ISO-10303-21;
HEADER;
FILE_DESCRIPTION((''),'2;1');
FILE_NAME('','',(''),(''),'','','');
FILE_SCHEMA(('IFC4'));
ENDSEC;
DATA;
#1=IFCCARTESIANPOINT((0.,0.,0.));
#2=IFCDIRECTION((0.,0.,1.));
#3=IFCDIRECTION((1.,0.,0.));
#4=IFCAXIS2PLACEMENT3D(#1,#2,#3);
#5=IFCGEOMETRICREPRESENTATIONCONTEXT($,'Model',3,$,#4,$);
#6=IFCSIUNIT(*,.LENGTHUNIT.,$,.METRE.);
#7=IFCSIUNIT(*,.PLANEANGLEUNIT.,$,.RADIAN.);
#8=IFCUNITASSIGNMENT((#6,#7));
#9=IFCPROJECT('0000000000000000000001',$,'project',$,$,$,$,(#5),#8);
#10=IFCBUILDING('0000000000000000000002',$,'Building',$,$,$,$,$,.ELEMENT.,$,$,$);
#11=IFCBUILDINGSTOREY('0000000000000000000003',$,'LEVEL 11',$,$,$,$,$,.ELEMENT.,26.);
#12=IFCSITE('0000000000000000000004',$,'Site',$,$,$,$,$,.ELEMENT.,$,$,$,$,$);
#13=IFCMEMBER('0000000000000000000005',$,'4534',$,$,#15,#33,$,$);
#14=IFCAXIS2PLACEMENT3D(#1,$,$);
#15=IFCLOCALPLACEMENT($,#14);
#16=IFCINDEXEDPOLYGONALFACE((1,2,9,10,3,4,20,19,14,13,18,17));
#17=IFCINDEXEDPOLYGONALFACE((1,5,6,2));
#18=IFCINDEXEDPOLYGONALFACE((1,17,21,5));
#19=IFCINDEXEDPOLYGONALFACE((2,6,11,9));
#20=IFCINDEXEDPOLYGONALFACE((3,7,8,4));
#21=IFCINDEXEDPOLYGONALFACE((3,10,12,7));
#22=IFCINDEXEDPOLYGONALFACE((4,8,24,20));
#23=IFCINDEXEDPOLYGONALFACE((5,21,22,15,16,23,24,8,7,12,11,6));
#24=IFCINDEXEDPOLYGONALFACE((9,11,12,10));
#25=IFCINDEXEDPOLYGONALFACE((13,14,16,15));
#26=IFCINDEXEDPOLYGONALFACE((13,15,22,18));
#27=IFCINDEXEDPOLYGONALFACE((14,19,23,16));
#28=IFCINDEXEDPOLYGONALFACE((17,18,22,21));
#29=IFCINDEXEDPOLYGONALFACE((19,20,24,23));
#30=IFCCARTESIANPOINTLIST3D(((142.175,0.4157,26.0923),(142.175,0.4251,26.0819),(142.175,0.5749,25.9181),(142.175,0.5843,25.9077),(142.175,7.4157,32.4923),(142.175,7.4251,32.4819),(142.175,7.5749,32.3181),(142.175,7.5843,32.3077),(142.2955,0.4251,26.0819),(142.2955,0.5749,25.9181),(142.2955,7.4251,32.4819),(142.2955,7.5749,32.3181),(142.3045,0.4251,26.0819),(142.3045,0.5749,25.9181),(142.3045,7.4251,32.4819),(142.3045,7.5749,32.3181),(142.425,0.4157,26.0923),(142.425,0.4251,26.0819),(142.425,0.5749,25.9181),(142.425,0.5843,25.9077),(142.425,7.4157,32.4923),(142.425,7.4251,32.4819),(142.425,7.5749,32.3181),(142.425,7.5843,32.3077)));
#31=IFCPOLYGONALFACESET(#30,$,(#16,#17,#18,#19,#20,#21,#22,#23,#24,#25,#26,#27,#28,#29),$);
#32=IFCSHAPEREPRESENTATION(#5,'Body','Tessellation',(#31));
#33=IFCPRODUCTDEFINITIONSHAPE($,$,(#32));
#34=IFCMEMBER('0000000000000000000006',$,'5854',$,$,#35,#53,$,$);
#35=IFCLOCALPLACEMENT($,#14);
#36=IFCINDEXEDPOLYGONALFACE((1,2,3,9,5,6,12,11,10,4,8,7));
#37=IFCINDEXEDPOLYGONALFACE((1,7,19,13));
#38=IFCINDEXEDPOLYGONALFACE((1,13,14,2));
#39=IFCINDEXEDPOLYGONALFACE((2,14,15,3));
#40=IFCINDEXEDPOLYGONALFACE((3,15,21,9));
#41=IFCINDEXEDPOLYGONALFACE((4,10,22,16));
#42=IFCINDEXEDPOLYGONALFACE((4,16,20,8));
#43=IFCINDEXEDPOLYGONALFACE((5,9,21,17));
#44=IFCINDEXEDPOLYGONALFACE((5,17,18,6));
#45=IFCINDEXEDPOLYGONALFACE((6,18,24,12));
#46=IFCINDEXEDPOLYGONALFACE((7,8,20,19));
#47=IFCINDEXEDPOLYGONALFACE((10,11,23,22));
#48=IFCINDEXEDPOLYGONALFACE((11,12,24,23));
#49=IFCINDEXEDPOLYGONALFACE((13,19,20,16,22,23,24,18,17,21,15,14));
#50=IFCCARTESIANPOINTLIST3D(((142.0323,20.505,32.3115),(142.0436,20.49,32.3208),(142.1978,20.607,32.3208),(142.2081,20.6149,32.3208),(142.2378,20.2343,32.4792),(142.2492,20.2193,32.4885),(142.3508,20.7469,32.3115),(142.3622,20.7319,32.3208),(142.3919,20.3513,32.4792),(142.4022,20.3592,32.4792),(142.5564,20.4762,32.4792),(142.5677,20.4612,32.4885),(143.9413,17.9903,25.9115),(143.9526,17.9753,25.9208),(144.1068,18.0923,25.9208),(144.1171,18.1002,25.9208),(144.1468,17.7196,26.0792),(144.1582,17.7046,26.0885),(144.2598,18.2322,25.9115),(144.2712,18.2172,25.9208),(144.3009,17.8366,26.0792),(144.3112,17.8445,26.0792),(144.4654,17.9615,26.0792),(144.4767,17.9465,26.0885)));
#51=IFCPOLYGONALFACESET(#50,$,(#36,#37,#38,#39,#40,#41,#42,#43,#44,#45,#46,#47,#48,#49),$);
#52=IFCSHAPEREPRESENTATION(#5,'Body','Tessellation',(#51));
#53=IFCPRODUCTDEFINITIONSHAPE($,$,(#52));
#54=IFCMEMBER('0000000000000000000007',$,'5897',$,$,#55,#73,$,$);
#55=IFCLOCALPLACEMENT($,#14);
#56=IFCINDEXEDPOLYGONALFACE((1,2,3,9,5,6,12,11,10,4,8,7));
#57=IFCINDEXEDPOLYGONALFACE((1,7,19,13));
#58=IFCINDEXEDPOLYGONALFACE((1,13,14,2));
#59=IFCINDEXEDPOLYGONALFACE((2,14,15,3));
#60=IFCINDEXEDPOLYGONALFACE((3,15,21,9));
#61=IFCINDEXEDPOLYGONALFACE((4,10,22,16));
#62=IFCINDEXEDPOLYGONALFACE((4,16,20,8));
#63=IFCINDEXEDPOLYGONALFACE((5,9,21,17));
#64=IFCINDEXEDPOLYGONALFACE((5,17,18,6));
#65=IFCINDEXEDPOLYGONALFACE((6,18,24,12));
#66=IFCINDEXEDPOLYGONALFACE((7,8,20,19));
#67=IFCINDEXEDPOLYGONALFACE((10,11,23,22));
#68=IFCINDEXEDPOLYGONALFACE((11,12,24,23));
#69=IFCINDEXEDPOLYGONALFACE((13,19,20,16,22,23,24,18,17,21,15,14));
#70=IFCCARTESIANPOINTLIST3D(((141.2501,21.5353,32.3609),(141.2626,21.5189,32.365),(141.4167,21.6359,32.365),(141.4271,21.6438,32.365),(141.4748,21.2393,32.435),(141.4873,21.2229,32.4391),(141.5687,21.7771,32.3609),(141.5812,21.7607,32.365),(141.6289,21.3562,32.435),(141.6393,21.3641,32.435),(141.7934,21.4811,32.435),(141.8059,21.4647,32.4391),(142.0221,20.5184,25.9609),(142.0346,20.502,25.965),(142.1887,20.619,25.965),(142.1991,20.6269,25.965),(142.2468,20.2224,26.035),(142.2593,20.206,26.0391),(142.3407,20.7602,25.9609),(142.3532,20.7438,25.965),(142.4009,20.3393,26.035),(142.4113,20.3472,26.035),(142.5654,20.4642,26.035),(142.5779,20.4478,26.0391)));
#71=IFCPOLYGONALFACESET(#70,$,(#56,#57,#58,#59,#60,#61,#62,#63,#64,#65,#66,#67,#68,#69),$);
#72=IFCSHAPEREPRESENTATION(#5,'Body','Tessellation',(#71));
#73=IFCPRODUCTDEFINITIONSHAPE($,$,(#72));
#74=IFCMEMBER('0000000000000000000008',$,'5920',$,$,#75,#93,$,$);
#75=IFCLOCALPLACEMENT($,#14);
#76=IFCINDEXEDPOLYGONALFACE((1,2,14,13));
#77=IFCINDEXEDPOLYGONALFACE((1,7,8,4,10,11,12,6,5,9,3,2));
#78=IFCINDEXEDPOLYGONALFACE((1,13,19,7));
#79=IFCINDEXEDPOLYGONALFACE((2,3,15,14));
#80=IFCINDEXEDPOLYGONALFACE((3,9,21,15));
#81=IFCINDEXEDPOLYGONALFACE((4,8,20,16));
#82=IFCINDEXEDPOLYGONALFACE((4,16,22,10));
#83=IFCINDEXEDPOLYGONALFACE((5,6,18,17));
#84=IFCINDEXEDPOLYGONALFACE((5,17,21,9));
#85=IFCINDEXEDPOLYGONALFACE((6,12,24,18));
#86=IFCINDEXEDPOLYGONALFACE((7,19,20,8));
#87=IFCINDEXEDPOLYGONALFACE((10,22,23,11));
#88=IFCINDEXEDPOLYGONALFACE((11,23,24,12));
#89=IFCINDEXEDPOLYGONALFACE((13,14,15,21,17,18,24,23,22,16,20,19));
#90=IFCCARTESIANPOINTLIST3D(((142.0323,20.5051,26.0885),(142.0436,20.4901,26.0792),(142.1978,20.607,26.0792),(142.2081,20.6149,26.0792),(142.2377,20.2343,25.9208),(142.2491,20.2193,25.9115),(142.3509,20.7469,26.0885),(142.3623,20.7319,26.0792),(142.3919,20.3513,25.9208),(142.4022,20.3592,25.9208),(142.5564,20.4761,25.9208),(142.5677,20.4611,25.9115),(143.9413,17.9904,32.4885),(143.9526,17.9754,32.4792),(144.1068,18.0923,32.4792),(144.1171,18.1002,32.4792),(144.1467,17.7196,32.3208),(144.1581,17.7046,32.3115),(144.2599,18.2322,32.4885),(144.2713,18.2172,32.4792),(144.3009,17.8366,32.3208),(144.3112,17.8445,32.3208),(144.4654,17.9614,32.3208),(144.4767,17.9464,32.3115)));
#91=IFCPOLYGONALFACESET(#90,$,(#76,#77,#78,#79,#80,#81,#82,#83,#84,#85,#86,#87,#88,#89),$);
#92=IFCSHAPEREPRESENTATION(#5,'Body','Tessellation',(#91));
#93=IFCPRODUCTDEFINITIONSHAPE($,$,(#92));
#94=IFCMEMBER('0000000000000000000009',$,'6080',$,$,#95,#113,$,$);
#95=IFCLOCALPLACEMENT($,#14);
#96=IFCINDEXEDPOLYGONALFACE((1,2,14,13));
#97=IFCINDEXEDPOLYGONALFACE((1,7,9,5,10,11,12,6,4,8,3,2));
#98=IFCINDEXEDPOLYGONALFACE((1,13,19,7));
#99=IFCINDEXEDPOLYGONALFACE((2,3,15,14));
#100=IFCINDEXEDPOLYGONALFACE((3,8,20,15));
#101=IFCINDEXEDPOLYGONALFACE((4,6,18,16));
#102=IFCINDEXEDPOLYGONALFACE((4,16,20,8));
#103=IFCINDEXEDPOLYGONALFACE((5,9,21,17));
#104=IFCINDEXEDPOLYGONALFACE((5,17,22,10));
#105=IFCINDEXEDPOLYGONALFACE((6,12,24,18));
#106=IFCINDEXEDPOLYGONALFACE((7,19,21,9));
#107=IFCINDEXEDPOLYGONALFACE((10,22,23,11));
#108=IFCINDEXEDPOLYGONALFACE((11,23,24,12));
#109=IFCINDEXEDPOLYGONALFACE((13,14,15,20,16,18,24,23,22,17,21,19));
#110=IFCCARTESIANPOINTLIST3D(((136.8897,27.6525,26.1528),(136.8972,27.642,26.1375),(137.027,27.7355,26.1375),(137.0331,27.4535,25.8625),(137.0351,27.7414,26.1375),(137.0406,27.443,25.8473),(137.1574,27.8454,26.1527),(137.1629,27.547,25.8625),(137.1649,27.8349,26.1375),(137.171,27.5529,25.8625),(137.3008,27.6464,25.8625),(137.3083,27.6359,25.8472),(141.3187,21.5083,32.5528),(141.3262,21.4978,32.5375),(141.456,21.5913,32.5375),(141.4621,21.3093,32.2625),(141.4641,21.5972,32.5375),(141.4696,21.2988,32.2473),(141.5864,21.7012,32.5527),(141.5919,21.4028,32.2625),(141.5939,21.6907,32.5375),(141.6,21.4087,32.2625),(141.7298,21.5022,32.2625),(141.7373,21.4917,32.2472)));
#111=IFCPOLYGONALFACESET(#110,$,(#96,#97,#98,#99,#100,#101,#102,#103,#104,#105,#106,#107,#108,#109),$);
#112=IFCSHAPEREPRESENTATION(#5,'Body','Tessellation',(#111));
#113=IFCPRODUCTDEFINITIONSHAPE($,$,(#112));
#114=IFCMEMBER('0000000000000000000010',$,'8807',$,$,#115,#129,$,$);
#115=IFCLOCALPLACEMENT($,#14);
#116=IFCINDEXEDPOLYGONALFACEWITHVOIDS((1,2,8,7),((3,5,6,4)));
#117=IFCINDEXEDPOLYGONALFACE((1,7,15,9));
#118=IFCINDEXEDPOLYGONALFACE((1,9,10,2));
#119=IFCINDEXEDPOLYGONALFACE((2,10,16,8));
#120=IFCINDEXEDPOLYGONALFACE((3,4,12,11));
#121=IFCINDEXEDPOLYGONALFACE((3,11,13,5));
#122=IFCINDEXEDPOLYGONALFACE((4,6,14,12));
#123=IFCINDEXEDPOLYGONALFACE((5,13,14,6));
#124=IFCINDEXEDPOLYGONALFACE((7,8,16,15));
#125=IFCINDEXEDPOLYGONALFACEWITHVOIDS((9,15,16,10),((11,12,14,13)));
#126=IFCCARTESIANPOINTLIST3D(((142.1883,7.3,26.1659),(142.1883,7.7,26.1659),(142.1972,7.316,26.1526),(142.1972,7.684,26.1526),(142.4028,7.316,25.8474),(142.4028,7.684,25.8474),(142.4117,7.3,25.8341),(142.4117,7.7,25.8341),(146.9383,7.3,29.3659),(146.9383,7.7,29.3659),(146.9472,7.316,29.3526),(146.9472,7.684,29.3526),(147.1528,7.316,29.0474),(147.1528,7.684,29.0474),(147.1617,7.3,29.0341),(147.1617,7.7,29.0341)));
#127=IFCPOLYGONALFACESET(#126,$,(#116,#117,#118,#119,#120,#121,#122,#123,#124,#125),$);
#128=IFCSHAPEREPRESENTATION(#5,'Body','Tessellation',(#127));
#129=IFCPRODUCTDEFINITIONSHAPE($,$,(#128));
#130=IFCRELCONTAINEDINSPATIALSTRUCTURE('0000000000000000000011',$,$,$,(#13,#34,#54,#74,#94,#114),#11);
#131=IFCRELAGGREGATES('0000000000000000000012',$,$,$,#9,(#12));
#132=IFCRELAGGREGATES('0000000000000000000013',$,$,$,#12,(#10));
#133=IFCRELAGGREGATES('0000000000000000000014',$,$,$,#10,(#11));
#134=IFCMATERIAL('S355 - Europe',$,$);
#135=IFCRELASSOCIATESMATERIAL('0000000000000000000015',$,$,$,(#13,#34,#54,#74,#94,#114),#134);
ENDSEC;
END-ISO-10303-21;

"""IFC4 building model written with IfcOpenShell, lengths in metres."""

from ifc_helpers import new_model, si_unit, frame, origin_with_axes, origin_2d_with_axis, place, context, project, spatial, hollow_rectangle, i_section, extrude, material, material_profile, profile_set, profile_usage, element, save


model = new_model("IFC4")

# Units and contexts
model_context = context("Model", 3, world=origin_with_axes())
ifc_project = project(units=[si_unit("LENGTHUNIT", "METRE"), si_unit("PLANEANGLEUNIT", "RADIAN")], contexts=[model_context])

# Site, building, storey
site = spatial("IfcSite", under=ifc_project, Name="Site", CompositionType="ELEMENT")
building = spatial("IfcBuilding", under=site, Name="Building", CompositionType="ELEMENT")
storey = spatial("IfcBuildingStorey", under=building, Name="LEVEL 11", CompositionType="ELEMENT", Elevation=26.0)

# Shared definitions
ifc_material = material(Name="S355 - Europe")

# Members
ifc_material_profile_1 = material_profile(ifc_material, i_section(OverallWidth=0.25, OverallDepth=0.25, WebThickness=0.009, FlangeThickness=0.014, at=origin_2d_with_axis()))
ifc_profile_set_1 = profile_set([ifc_material_profile_1])
ifc_profile_usage_1 = profile_usage(ifc_profile_set_1, cardinal=10)
member_1_placement = place(None, frame((142.3, 7.5, 32.4), z_axis=(0.0, -0.738029, -0.674769), x_axis=(1.0, 0.0, 0.0)))
element("IfcMember", 1, at=member_1_placement, inside=storey, material=ifc_profile_usage_1, Name="4534", context=model_context, shape_type="SweptSolid", body=[
    extrude(i_section(OverallWidth=0.25, OverallDepth=0.25, WebThickness=0.009, FlangeThickness=0.014, at=origin_2d_with_axis()), origin_with_axes(), (0.0, 0.0, 1.0), 9.4847),
])
ifc_material_profile_2 = material_profile(ifc_material, i_section(OverallWidth=0.4, OverallDepth=0.4, WebThickness=0.013, FlangeThickness=0.021, at=origin_2d_with_axis()))
ifc_profile_set_2 = profile_set([ifc_material_profile_2])
ifc_profile_usage_2 = profile_usage(ifc_profile_set_2, cardinal=10)
member_2_placement = place(None, frame((144.209, 17.9684, 26.0), z_axis=(-0.267502, 0.352377, 0.896813), x_axis=(-0.796493, -0.604647, 0.0)))
element("IfcMember", 2, at=member_2_placement, inside=storey, material=ifc_profile_usage_2, Name="5854", context=model_context, shape_type="SweptSolid", body=[
    extrude(i_section(OverallWidth=0.4, OverallDepth=0.4, WebThickness=0.013, FlangeThickness=0.021, at=origin_2d_with_axis()), origin_with_axes(), (0.0, 0.0, 1.0), 7.1364),
])
ifc_material_profile_3 = material_profile(ifc_material, i_section(OverallWidth=0.4, OverallDepth=0.4, WebThickness=0.013, FlangeThickness=0.021, at=origin_2d_with_axis()))
ifc_profile_set_3 = profile_set([ifc_material_profile_3])
ifc_profile_usage_3 = profile_usage(ifc_profile_set_3, cardinal=10)
member_3_placement = place(None, frame((141.528, 21.5, 32.4), z_axis=(0.118294, -0.15582, -0.980677), x_axis=(0.796587, 0.604524, 0.0)))
element("IfcMember", 3, at=member_3_placement, inside=storey, material=ifc_profile_usage_3, Name="5897", context=model_context, shape_type="SweptSolid", body=[
    extrude(i_section(OverallWidth=0.4, OverallDepth=0.4, WebThickness=0.013, FlangeThickness=0.021, at=origin_2d_with_axis()), origin_with_axes(), (0.0, 0.0, 1.0), 6.5261),
])
ifc_material_profile_4 = material_profile(ifc_material, i_section(OverallWidth=0.4, OverallDepth=0.4, WebThickness=0.013, FlangeThickness=0.021, at=origin_2d_with_axis()))
ifc_profile_set_4 = profile_set([ifc_material_profile_4])
ifc_profile_usage_4 = profile_usage(ifc_profile_set_4, cardinal=10)
member_4_placement = place(None, frame((142.3, 20.4831, 26.0), z_axis=(0.267502, -0.352377, 0.896813), x_axis=(0.796587, 0.604524, 0.0)))
element("IfcMember", 4, at=member_4_placement, inside=storey, material=ifc_profile_usage_4, Name="5920", context=model_context, shape_type="SweptSolid", body=[
    extrude(i_section(OverallWidth=0.4, OverallDepth=0.4, WebThickness=0.013, FlangeThickness=0.021, at=origin_2d_with_axis()), origin_with_axes(), (0.0, 0.0, 1.0), 7.1364),
])
ifc_material_profile_5 = material_profile(ifc_material, i_section(OverallWidth=0.33, OverallDepth=0.4, WebThickness=0.01, FlangeThickness=0.02, at=origin_2d_with_axis()))
ifc_profile_set_5 = profile_set([ifc_material_profile_5])
ifc_profile_usage_5 = profile_usage(ifc_profile_set_5, cardinal=10)
member_5_placement = place(None, frame((141.528, 21.5, 32.4), z_axis=(-0.446651, 0.619624, -0.645421), x_axis=(-0.811322, -0.584599, 0.0)))
element("IfcMember", 5, at=member_5_placement, inside=storey, material=ifc_profile_usage_5, Name="6080", context=model_context, shape_type="SweptSolid", body=[
    extrude(i_section(OverallWidth=0.33, OverallDepth=0.4, WebThickness=0.01, FlangeThickness=0.02, at=origin_2d_with_axis()), origin_with_axes(), (0.0, 0.0, 1.0), 9.916),
])
ifc_material_profile_6 = material_profile(ifc_material, hollow_rectangle(XDim=0.4, YDim=0.4, WallThickness=0.016, at=origin_2d_with_axis()))
ifc_profile_set_6 = profile_set([ifc_material_profile_6])
ifc_profile_usage_6 = profile_usage(ifc_profile_set_6, cardinal=10)
member_6_placement = place(None, frame((142.3, 7.5, 26.0), z_axis=(0.829354, 0.0, 0.558723), x_axis=(0.0, 1.0, 0.0)))
element("IfcMember", 6, at=member_6_placement, inside=storey, material=ifc_profile_usage_6, Name="8807", context=model_context, shape_type="SweptSolid", body=[
    extrude(hollow_rectangle(XDim=0.4, YDim=0.4, WallThickness=0.016, at=origin_2d_with_axis()), origin_with_axes(), (0.0, 0.0, 1.0), 5.7273),
])

save(model, "model.ifc")
